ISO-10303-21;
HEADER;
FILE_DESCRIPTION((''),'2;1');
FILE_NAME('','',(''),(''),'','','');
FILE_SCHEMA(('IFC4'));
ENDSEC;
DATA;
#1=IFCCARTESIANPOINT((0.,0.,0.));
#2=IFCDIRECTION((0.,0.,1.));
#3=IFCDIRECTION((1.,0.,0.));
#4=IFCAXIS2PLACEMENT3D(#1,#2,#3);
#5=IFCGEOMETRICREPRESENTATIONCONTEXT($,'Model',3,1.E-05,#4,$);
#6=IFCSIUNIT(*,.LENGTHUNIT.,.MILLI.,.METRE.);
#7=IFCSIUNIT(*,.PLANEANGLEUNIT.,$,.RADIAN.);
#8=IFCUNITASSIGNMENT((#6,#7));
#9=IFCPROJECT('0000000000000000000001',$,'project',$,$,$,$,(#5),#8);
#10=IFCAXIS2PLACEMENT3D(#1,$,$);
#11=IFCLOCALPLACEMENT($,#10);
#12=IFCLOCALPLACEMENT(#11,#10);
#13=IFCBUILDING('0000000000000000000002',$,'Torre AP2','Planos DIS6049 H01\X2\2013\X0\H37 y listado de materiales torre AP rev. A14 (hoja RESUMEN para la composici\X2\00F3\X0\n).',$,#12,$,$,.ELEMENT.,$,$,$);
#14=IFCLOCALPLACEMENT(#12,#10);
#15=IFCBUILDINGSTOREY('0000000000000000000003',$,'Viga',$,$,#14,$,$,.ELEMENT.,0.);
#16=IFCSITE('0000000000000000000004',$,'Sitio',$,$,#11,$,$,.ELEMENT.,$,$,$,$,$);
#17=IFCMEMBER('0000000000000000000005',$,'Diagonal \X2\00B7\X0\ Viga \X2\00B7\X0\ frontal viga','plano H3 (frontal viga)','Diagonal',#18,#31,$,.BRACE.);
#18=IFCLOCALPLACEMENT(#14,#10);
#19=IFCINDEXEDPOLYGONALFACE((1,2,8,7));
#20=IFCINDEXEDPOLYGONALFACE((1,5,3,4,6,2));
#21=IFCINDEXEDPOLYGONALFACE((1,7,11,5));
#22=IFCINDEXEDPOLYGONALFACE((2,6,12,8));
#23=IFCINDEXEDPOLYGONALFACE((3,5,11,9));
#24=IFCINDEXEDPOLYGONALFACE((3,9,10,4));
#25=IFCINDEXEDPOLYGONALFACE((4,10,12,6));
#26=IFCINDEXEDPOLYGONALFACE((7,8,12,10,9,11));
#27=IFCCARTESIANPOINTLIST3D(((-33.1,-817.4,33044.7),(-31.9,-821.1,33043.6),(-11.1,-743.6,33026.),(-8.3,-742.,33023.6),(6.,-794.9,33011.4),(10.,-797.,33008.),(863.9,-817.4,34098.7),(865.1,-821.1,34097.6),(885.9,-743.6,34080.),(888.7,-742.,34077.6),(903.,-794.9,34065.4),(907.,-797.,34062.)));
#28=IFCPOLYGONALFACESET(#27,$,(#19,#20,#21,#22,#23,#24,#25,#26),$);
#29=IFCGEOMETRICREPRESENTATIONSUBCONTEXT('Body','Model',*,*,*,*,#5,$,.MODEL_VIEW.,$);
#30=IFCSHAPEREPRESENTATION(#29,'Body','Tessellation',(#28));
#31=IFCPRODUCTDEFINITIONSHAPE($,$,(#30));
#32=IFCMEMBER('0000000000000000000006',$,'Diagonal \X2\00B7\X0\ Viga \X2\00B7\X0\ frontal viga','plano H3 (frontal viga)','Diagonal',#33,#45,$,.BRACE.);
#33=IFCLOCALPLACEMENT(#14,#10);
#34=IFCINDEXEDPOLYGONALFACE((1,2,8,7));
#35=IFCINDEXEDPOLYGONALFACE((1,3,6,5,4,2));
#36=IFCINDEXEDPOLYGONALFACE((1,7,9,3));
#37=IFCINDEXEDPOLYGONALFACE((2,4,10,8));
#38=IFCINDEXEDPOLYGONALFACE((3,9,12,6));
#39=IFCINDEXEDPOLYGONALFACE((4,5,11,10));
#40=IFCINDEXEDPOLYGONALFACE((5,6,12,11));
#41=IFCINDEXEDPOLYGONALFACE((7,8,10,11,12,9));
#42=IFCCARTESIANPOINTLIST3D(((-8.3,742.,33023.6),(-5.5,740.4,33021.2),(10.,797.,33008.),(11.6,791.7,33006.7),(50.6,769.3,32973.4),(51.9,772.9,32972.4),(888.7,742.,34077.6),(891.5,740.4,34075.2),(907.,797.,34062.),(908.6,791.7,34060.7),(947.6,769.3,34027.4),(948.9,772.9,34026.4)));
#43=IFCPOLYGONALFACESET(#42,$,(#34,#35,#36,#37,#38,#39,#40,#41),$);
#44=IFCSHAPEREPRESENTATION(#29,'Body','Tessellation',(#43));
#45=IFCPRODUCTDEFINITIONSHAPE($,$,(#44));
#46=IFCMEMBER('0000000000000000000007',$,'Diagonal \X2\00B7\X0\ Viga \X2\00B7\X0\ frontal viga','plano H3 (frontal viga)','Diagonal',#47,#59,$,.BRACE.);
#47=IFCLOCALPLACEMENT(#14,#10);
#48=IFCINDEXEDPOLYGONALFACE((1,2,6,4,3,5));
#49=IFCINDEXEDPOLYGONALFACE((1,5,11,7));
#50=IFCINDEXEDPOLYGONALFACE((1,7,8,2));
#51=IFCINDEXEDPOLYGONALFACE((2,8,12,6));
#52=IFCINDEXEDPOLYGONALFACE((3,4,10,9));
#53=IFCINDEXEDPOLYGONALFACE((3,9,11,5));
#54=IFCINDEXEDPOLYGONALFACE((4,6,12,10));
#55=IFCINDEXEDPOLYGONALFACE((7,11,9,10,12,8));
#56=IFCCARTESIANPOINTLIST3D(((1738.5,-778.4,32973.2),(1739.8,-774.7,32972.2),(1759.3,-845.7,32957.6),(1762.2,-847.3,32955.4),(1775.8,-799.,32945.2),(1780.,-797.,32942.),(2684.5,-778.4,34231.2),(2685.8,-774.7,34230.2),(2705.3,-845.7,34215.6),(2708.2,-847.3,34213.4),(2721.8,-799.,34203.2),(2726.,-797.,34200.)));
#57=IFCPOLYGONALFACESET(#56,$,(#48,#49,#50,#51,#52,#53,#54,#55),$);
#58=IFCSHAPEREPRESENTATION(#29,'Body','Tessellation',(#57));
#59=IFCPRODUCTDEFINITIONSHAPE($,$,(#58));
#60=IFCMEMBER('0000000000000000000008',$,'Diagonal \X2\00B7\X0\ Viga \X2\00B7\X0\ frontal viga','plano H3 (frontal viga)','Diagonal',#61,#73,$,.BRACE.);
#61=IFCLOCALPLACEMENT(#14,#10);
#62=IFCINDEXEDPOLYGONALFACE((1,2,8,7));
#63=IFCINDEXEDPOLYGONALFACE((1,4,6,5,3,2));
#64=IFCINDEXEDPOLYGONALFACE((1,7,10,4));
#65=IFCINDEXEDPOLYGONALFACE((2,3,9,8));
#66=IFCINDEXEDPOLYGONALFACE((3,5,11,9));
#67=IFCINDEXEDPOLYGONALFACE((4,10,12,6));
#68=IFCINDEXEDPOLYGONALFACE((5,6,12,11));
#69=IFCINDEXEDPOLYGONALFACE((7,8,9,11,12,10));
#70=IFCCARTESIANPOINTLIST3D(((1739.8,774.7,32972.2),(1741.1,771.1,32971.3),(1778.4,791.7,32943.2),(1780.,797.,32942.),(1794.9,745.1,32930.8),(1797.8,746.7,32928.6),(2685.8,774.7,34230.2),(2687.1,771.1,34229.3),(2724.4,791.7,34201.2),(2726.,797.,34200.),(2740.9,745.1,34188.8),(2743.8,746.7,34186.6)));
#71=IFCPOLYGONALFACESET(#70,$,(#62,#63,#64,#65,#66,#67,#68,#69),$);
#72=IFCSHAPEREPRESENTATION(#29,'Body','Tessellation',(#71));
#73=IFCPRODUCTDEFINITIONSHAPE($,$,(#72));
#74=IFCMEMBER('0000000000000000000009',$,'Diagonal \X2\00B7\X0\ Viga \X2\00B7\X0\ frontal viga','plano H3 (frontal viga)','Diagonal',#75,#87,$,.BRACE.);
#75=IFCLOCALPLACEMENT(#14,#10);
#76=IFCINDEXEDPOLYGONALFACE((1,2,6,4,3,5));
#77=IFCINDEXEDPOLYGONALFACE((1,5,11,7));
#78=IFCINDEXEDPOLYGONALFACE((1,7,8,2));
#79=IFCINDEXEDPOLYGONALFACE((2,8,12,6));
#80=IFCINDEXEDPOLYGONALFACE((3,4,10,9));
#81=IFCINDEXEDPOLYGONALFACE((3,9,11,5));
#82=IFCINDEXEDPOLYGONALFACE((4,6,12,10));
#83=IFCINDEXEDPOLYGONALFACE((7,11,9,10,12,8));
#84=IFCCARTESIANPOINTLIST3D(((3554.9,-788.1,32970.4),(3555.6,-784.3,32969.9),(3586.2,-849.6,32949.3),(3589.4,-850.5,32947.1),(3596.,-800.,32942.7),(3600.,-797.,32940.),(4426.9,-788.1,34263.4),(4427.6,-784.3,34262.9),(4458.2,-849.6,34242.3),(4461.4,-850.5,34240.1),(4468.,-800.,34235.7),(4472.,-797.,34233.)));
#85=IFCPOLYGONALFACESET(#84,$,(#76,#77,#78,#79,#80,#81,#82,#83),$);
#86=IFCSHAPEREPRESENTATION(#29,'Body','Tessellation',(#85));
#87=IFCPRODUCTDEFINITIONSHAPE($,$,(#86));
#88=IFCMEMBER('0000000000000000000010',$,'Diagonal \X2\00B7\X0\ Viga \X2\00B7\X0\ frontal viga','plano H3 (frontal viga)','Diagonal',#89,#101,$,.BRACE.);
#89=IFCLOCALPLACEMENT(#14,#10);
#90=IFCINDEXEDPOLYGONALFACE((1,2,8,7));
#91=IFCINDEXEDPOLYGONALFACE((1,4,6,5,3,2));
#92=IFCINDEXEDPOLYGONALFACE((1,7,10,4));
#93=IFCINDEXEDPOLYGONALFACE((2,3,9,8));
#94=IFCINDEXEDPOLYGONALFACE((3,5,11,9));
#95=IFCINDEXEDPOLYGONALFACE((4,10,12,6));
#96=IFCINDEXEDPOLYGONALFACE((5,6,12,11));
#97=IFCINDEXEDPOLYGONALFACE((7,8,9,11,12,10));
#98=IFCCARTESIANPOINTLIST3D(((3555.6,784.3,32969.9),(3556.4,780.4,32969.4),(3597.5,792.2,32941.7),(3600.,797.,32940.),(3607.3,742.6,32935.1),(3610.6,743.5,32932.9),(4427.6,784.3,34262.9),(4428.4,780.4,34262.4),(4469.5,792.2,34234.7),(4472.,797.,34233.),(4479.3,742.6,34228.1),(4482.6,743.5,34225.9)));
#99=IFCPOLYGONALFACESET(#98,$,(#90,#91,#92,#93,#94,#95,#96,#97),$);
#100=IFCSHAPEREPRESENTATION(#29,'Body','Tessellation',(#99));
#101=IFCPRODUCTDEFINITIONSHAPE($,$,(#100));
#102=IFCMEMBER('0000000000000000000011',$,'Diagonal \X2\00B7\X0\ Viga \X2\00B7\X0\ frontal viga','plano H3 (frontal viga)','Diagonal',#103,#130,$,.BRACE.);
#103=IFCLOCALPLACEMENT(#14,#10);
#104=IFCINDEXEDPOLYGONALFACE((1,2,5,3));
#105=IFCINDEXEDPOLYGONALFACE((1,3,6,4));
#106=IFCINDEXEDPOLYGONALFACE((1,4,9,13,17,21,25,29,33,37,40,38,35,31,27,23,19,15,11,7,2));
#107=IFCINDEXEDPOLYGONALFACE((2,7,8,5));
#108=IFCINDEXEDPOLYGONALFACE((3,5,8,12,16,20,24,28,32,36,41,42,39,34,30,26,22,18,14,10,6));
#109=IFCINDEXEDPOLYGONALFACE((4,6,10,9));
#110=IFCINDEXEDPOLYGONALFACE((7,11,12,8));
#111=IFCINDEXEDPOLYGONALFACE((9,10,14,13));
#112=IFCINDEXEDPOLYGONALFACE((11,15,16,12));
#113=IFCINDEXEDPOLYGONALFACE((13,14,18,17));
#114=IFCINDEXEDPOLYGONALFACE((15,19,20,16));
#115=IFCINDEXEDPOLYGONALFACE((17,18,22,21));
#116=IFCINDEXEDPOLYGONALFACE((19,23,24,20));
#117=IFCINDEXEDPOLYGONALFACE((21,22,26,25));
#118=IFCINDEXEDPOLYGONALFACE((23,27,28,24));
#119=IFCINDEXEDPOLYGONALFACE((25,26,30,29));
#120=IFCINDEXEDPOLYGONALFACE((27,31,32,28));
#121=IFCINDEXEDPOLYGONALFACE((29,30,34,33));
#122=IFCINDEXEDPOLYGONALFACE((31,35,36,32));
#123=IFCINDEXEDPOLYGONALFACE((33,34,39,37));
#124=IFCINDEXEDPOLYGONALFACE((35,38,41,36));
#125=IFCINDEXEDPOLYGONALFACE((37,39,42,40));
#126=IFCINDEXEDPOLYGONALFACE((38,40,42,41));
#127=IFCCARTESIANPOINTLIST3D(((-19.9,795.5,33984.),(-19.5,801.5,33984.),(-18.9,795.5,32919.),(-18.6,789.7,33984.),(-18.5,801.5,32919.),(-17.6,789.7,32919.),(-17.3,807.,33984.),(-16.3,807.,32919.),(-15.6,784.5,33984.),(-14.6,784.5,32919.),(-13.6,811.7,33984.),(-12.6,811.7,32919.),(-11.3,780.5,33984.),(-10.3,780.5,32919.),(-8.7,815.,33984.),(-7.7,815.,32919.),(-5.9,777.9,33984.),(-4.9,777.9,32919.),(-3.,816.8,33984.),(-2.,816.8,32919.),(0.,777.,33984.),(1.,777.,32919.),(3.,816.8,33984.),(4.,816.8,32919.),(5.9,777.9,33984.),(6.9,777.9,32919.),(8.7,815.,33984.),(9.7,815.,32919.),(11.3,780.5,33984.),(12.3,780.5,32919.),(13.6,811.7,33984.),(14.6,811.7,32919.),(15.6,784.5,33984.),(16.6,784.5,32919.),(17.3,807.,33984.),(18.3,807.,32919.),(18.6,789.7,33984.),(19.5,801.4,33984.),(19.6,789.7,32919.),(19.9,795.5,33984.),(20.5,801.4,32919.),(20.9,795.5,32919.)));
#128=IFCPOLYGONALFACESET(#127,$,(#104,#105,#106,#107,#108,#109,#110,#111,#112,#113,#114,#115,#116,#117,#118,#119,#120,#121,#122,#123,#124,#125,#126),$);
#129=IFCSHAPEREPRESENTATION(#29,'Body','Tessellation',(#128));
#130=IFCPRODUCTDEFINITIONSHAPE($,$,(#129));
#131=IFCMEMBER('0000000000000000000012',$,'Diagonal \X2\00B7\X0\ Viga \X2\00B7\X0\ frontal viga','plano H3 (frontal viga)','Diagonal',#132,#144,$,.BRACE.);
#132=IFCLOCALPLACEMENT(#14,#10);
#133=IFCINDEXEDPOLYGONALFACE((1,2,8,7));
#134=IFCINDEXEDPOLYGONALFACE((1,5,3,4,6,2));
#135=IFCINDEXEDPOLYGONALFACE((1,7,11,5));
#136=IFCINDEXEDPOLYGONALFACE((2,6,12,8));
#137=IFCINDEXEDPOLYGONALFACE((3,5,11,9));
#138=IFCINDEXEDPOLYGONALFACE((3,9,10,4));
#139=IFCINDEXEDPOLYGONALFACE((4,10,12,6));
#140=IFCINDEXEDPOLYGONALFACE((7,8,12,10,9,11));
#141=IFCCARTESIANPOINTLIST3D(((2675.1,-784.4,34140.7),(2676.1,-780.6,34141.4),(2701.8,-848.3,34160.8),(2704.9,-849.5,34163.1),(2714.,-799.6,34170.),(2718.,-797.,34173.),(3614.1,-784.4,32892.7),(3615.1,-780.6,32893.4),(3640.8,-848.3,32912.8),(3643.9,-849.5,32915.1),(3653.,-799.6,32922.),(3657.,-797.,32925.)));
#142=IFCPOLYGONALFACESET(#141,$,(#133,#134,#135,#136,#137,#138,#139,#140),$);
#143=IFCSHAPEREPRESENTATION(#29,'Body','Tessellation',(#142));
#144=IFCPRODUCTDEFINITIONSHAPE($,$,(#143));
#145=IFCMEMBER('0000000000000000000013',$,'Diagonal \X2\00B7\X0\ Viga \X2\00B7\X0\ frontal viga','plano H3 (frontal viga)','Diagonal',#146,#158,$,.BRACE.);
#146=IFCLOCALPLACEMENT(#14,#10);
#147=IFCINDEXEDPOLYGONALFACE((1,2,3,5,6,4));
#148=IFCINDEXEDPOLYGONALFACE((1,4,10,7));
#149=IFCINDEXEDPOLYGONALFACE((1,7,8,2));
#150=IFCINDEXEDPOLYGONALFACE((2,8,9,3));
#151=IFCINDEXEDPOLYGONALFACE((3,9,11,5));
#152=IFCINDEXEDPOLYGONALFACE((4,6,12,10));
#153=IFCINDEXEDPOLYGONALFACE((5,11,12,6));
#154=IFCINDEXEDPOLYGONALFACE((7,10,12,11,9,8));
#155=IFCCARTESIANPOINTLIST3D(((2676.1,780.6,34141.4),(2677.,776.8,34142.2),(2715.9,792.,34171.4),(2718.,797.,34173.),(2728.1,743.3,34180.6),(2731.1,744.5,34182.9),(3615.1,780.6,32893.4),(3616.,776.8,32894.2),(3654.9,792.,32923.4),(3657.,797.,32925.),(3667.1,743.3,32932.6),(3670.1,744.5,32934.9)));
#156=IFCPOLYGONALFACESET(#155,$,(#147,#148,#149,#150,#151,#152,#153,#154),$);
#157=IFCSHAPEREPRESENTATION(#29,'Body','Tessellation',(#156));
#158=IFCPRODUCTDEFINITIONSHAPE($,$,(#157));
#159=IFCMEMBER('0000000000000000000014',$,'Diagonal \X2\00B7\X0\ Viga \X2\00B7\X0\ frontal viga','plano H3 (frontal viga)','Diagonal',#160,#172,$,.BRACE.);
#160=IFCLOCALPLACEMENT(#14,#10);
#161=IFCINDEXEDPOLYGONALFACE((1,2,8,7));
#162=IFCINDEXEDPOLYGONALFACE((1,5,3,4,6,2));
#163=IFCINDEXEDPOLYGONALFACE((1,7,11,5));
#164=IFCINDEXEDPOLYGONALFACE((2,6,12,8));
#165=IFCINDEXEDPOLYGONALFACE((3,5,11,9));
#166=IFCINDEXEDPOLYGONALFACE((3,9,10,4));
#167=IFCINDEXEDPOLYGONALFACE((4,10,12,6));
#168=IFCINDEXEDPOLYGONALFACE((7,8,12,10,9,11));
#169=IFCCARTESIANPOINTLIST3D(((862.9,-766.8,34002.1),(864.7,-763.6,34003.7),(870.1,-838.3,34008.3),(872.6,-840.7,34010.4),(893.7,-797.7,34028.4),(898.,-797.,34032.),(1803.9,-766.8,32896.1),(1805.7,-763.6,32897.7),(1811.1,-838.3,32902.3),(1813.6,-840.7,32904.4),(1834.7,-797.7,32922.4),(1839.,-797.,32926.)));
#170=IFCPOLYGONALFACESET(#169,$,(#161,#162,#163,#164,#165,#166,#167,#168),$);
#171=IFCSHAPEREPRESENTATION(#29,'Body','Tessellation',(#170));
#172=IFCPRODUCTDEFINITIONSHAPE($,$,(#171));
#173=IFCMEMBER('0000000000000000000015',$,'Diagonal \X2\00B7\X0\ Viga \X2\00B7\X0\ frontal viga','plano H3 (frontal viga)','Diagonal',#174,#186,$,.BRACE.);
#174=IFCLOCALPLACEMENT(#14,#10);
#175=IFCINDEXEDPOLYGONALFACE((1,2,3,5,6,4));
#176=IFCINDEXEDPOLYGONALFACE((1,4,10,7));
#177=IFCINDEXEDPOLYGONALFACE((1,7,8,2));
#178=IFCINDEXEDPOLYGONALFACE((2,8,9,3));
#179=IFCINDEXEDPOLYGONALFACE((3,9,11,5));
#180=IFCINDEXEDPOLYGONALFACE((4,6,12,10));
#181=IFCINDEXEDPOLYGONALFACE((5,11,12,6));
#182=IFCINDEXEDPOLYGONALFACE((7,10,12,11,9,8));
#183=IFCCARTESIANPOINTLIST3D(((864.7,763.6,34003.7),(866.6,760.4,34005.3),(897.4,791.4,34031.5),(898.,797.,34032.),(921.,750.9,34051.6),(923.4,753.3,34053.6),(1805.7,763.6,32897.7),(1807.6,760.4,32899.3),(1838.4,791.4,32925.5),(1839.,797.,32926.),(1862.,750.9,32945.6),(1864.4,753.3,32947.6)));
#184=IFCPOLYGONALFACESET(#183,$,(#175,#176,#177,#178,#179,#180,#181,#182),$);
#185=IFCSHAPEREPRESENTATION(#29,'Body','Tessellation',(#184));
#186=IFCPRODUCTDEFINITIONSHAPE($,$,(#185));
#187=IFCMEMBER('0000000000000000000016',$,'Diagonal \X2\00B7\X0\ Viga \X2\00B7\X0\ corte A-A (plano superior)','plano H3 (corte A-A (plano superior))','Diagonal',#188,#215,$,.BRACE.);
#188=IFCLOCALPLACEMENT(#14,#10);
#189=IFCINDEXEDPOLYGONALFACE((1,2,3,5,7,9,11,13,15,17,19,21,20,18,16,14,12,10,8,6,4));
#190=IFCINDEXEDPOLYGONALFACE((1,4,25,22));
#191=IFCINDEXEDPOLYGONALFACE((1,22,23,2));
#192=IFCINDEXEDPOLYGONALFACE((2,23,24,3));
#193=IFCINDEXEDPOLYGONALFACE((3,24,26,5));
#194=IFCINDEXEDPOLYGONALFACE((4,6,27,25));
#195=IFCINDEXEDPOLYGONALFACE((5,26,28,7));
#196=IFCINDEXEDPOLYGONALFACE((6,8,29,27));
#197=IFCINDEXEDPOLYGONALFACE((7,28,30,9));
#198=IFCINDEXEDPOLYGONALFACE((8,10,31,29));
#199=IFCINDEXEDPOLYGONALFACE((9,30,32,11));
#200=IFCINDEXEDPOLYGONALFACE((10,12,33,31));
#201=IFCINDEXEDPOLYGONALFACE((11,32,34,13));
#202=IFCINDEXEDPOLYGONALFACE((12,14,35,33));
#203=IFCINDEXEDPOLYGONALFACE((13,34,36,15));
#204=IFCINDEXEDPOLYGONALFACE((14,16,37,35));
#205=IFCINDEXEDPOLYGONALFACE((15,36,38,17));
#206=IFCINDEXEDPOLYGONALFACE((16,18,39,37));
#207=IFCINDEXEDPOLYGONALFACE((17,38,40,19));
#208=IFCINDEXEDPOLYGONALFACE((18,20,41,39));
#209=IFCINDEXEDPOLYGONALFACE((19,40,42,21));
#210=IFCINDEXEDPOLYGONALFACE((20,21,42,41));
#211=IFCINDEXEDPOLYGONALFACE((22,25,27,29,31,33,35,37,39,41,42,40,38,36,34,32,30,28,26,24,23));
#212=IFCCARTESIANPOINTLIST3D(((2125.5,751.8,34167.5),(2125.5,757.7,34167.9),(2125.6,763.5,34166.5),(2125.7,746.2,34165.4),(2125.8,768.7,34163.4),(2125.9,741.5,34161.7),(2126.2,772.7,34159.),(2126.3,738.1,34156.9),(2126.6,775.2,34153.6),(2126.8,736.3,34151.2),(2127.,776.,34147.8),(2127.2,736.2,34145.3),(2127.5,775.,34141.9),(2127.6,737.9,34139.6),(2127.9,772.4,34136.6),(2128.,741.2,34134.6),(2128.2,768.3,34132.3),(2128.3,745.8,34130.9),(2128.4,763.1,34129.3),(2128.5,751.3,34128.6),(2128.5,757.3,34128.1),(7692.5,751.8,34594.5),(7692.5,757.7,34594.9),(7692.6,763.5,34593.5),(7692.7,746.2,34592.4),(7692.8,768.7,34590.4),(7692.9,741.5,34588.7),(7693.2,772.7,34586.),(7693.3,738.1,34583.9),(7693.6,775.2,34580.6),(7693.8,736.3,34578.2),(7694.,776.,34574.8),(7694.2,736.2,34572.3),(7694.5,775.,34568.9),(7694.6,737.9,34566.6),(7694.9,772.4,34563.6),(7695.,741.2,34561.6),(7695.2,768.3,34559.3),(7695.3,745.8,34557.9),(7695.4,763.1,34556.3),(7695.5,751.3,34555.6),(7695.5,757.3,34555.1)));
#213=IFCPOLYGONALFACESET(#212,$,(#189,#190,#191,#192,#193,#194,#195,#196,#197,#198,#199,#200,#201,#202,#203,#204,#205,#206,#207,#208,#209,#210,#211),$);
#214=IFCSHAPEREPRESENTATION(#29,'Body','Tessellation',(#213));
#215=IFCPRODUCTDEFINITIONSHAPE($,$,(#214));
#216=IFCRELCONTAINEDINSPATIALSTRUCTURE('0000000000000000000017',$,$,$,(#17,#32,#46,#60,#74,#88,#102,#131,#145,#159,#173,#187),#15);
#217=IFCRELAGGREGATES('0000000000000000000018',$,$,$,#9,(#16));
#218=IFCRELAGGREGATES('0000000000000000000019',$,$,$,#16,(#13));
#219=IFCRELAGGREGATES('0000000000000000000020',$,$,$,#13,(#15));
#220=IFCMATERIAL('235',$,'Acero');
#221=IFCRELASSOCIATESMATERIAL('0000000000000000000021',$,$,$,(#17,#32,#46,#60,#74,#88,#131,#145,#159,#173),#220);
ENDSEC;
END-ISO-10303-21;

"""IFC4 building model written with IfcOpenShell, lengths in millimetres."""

from ifc_helpers import new_model, si_unit, frame, frame_2d, origin, origin_with_axes, place, context, subcontext, project, spatial, circle, l_section, extrude, material, element, save


model = new_model("IFC4")

# Units and contexts
model_context = context("Model", 3, precision=1e-05, world=origin_with_axes())
body_context = subcontext(model_context, "Body", "Model", "MODEL_VIEW")
ifc_project = project(units=[si_unit("LENGTHUNIT", "METRE", prefix="MILLI"), si_unit("PLANEANGLEUNIT", "RADIAN")], contexts=[model_context])

# Site, building, storey
site_placement = place(None, origin())
site = spatial("IfcSite", under=ifc_project, at=site_placement, Name="Sitio", CompositionType="ELEMENT")
building_placement = place(site_placement, origin())
building = spatial("IfcBuilding", under=site, at=building_placement, Name="Torre AP2", Description="Planos DIS6049 H01–H37 y listado de materiales torre AP rev. A14 (hoja RESUMEN para la composición).", CompositionType="ELEMENT")
storey_placement = place(building_placement, origin())
storey = spatial("IfcBuildingStorey", under=building, at=storey_placement, Name="Viga", CompositionType="ELEMENT", Elevation=0.0)

# Members
ifc_material = material(Name="235", Category="Acero")
for number, where, z_axis, x_axis, name in (
    (1, (10.0, -797.0, 33008.0), (0.64811, 0.0, 0.761547), (-0.305596, 0.915954, 0.260076), "Diagonal · Viga · frontal viga"),
    (2, (10.0, 797.0, 33008.0), (0.64811, 0.0, 0.761547), (-0.305596, -0.915954, 0.260076), "Diagonal · Viga · frontal viga"),
):
    element("IfcMember", number, at=place(storey_placement, frame(where, z_axis=z_axis, x_axis=x_axis)), inside=storey, material=ifc_material, Name=name, Description="plano H3 (frontal viga)", ObjectType="Diagonal", PredefinedType="BRACE", context=body_context, shape_type="SweptSolid", body=[
        extrude(l_section(Depth=60.0, Width=60.0, Thickness=4.0, at=frame_2d((30.0, 30.0))), None, (0.0, 0.0, 1.0), 1384.0),
    ])
for number, where, z_axis, x_axis, name in (
    (3, (1780.0, -797.0, 32942.0), (0.601016, 0.0, 0.799237), (-0.730849, 0.404737, 0.549589), "Diagonal · Viga · frontal viga"),
    (4, (1780.0, 797.0, 32942.0), (0.601016, 0.0, 0.799237), (-0.730849, -0.404737, 0.549589), "Diagonal · Viga · frontal viga"),
):
    element("IfcMember", number, at=place(storey_placement, frame(where, z_axis=z_axis, x_axis=x_axis)), inside=storey, material=ifc_material, Name=name, Description="plano H3 (frontal viga)", ObjectType="Diagonal", PredefinedType="BRACE", context=body_context, shape_type="SweptSolid", body=[
        extrude(l_section(Depth=55.0, Width=55.0, Thickness=4.0, at=frame_2d((27.5, 27.5))), None, (0.0, 0.0, 1.0), 1574.0),
    ])
for number, where, z_axis, x_axis, name in (
    (5, (3600.0, -797.0, 32940.0), (0.559131, 0.0, 0.829079), (-0.806517, 0.231702, 0.543916), "Diagonal · Viga · frontal viga"),
    (6, (3600.0, 797.0, 32940.0), (0.559131, 0.0, 0.829079), (-0.806517, -0.231702, 0.543916), "Diagonal · Viga · frontal viga"),
):
    element("IfcMember", number, at=place(storey_placement, frame(where, z_axis=z_axis, x_axis=x_axis)), inside=storey, material=ifc_material, Name=name, Description="plano H3 (frontal viga)", ObjectType="Diagonal", PredefinedType="BRACE", context=body_context, shape_type="SweptSolid", body=[
        extrude(l_section(Depth=55.0, Width=55.0, Thickness=4.0, at=frame_2d((27.5, 27.5))), None, (0.0, 0.0, 1.0), 1559.6),
    ])
member_1_placement = place(storey_placement, frame((1.0, 797.0, 32919.0), z_axis=(-0.000939, 0.0, 1.0), x_axis=(-0.000627, -1.0, -0.000001)))
element("IfcMember", 7, at=member_1_placement, inside=storey, Name="Diagonal · Viga · frontal viga", Description="plano H3 (frontal viga)", ObjectType="Diagonal", PredefinedType="BRACE", context=body_context, shape_type="SweptSolid", body=[
    extrude(circle(Radius=20.0), None, (0.0, 0.0, 1.0), 1065.0),
])
for number, where, z_axis, x_axis, name in (
    (8, (3657.0, -797.0, 32925.0), (-0.601229, 0.0, 0.799077), (-0.762614, 0.298631, -0.573794), "Diagonal · Viga · frontal viga"),
    (9, (3657.0, 797.0, 32925.0), (-0.601229, 0.0, 0.799077), (-0.762614, -0.298631, -0.573794), "Diagonal · Viga · frontal viga"),
):
    element("IfcMember", number, at=place(storey_placement, frame(where, z_axis=z_axis, x_axis=x_axis)), inside=storey, material=ifc_material, Name=name, Description="plano H3 (frontal viga)", ObjectType="Diagonal", PredefinedType="BRACE", context=body_context, shape_type="SweptSolid", body=[
        extrude(l_section(Depth=55.0, Width=55.0, Thickness=4.0, at=frame_2d((27.5, 27.5))), None, (0.0, 0.0, 1.0), 1561.8),
    ])
for number, where, z_axis, x_axis, name in (
    (10, (1839.0, -797.0, 32926.0), (-0.648008, 0.0, 0.761633), (-0.605023, 0.607426, -0.514762), "Diagonal · Viga · frontal viga"),
    (11, (1839.0, 797.0, 32926.0), (-0.648008, 0.0, 0.761633), (-0.605023, -0.607426, -0.514762), "Diagonal · Viga · frontal viga"),
):
    element("IfcMember", number, at=place(storey_placement, frame(where, z_axis=z_axis, x_axis=x_axis)), inside=storey, material=ifc_material, Name=name, Description="plano H3 (frontal viga)", ObjectType="Diagonal", PredefinedType="BRACE", context=body_context, shape_type="SweptSolid", body=[
        extrude(l_section(Depth=55.0, Width=55.0, Thickness=4.0, at=frame_2d((27.5, 27.5))), None, (0.0, 0.0, 1.0), 1452.1),
    ])
member_2_placement = place(storey_placement, frame((2127.0, 756.0, 34148.0), z_axis=(0.997071, 0.0, 0.076477), x_axis=(-0.034023, -0.895589, 0.44358)))
element("IfcMember", 12, at=member_2_placement, inside=storey, Name="Diagonal · Viga · corte A-A (plano superior)", Description="plano H3 (corte A-A (plano superior))", ObjectType="Diagonal", PredefinedType="BRACE", context=body_context, shape_type="SweptSolid", body=[
    extrude(circle(Radius=20.0), None, (0.0, 0.0, 1.0), 5583.4),
])

save(model, "model.ifc")
